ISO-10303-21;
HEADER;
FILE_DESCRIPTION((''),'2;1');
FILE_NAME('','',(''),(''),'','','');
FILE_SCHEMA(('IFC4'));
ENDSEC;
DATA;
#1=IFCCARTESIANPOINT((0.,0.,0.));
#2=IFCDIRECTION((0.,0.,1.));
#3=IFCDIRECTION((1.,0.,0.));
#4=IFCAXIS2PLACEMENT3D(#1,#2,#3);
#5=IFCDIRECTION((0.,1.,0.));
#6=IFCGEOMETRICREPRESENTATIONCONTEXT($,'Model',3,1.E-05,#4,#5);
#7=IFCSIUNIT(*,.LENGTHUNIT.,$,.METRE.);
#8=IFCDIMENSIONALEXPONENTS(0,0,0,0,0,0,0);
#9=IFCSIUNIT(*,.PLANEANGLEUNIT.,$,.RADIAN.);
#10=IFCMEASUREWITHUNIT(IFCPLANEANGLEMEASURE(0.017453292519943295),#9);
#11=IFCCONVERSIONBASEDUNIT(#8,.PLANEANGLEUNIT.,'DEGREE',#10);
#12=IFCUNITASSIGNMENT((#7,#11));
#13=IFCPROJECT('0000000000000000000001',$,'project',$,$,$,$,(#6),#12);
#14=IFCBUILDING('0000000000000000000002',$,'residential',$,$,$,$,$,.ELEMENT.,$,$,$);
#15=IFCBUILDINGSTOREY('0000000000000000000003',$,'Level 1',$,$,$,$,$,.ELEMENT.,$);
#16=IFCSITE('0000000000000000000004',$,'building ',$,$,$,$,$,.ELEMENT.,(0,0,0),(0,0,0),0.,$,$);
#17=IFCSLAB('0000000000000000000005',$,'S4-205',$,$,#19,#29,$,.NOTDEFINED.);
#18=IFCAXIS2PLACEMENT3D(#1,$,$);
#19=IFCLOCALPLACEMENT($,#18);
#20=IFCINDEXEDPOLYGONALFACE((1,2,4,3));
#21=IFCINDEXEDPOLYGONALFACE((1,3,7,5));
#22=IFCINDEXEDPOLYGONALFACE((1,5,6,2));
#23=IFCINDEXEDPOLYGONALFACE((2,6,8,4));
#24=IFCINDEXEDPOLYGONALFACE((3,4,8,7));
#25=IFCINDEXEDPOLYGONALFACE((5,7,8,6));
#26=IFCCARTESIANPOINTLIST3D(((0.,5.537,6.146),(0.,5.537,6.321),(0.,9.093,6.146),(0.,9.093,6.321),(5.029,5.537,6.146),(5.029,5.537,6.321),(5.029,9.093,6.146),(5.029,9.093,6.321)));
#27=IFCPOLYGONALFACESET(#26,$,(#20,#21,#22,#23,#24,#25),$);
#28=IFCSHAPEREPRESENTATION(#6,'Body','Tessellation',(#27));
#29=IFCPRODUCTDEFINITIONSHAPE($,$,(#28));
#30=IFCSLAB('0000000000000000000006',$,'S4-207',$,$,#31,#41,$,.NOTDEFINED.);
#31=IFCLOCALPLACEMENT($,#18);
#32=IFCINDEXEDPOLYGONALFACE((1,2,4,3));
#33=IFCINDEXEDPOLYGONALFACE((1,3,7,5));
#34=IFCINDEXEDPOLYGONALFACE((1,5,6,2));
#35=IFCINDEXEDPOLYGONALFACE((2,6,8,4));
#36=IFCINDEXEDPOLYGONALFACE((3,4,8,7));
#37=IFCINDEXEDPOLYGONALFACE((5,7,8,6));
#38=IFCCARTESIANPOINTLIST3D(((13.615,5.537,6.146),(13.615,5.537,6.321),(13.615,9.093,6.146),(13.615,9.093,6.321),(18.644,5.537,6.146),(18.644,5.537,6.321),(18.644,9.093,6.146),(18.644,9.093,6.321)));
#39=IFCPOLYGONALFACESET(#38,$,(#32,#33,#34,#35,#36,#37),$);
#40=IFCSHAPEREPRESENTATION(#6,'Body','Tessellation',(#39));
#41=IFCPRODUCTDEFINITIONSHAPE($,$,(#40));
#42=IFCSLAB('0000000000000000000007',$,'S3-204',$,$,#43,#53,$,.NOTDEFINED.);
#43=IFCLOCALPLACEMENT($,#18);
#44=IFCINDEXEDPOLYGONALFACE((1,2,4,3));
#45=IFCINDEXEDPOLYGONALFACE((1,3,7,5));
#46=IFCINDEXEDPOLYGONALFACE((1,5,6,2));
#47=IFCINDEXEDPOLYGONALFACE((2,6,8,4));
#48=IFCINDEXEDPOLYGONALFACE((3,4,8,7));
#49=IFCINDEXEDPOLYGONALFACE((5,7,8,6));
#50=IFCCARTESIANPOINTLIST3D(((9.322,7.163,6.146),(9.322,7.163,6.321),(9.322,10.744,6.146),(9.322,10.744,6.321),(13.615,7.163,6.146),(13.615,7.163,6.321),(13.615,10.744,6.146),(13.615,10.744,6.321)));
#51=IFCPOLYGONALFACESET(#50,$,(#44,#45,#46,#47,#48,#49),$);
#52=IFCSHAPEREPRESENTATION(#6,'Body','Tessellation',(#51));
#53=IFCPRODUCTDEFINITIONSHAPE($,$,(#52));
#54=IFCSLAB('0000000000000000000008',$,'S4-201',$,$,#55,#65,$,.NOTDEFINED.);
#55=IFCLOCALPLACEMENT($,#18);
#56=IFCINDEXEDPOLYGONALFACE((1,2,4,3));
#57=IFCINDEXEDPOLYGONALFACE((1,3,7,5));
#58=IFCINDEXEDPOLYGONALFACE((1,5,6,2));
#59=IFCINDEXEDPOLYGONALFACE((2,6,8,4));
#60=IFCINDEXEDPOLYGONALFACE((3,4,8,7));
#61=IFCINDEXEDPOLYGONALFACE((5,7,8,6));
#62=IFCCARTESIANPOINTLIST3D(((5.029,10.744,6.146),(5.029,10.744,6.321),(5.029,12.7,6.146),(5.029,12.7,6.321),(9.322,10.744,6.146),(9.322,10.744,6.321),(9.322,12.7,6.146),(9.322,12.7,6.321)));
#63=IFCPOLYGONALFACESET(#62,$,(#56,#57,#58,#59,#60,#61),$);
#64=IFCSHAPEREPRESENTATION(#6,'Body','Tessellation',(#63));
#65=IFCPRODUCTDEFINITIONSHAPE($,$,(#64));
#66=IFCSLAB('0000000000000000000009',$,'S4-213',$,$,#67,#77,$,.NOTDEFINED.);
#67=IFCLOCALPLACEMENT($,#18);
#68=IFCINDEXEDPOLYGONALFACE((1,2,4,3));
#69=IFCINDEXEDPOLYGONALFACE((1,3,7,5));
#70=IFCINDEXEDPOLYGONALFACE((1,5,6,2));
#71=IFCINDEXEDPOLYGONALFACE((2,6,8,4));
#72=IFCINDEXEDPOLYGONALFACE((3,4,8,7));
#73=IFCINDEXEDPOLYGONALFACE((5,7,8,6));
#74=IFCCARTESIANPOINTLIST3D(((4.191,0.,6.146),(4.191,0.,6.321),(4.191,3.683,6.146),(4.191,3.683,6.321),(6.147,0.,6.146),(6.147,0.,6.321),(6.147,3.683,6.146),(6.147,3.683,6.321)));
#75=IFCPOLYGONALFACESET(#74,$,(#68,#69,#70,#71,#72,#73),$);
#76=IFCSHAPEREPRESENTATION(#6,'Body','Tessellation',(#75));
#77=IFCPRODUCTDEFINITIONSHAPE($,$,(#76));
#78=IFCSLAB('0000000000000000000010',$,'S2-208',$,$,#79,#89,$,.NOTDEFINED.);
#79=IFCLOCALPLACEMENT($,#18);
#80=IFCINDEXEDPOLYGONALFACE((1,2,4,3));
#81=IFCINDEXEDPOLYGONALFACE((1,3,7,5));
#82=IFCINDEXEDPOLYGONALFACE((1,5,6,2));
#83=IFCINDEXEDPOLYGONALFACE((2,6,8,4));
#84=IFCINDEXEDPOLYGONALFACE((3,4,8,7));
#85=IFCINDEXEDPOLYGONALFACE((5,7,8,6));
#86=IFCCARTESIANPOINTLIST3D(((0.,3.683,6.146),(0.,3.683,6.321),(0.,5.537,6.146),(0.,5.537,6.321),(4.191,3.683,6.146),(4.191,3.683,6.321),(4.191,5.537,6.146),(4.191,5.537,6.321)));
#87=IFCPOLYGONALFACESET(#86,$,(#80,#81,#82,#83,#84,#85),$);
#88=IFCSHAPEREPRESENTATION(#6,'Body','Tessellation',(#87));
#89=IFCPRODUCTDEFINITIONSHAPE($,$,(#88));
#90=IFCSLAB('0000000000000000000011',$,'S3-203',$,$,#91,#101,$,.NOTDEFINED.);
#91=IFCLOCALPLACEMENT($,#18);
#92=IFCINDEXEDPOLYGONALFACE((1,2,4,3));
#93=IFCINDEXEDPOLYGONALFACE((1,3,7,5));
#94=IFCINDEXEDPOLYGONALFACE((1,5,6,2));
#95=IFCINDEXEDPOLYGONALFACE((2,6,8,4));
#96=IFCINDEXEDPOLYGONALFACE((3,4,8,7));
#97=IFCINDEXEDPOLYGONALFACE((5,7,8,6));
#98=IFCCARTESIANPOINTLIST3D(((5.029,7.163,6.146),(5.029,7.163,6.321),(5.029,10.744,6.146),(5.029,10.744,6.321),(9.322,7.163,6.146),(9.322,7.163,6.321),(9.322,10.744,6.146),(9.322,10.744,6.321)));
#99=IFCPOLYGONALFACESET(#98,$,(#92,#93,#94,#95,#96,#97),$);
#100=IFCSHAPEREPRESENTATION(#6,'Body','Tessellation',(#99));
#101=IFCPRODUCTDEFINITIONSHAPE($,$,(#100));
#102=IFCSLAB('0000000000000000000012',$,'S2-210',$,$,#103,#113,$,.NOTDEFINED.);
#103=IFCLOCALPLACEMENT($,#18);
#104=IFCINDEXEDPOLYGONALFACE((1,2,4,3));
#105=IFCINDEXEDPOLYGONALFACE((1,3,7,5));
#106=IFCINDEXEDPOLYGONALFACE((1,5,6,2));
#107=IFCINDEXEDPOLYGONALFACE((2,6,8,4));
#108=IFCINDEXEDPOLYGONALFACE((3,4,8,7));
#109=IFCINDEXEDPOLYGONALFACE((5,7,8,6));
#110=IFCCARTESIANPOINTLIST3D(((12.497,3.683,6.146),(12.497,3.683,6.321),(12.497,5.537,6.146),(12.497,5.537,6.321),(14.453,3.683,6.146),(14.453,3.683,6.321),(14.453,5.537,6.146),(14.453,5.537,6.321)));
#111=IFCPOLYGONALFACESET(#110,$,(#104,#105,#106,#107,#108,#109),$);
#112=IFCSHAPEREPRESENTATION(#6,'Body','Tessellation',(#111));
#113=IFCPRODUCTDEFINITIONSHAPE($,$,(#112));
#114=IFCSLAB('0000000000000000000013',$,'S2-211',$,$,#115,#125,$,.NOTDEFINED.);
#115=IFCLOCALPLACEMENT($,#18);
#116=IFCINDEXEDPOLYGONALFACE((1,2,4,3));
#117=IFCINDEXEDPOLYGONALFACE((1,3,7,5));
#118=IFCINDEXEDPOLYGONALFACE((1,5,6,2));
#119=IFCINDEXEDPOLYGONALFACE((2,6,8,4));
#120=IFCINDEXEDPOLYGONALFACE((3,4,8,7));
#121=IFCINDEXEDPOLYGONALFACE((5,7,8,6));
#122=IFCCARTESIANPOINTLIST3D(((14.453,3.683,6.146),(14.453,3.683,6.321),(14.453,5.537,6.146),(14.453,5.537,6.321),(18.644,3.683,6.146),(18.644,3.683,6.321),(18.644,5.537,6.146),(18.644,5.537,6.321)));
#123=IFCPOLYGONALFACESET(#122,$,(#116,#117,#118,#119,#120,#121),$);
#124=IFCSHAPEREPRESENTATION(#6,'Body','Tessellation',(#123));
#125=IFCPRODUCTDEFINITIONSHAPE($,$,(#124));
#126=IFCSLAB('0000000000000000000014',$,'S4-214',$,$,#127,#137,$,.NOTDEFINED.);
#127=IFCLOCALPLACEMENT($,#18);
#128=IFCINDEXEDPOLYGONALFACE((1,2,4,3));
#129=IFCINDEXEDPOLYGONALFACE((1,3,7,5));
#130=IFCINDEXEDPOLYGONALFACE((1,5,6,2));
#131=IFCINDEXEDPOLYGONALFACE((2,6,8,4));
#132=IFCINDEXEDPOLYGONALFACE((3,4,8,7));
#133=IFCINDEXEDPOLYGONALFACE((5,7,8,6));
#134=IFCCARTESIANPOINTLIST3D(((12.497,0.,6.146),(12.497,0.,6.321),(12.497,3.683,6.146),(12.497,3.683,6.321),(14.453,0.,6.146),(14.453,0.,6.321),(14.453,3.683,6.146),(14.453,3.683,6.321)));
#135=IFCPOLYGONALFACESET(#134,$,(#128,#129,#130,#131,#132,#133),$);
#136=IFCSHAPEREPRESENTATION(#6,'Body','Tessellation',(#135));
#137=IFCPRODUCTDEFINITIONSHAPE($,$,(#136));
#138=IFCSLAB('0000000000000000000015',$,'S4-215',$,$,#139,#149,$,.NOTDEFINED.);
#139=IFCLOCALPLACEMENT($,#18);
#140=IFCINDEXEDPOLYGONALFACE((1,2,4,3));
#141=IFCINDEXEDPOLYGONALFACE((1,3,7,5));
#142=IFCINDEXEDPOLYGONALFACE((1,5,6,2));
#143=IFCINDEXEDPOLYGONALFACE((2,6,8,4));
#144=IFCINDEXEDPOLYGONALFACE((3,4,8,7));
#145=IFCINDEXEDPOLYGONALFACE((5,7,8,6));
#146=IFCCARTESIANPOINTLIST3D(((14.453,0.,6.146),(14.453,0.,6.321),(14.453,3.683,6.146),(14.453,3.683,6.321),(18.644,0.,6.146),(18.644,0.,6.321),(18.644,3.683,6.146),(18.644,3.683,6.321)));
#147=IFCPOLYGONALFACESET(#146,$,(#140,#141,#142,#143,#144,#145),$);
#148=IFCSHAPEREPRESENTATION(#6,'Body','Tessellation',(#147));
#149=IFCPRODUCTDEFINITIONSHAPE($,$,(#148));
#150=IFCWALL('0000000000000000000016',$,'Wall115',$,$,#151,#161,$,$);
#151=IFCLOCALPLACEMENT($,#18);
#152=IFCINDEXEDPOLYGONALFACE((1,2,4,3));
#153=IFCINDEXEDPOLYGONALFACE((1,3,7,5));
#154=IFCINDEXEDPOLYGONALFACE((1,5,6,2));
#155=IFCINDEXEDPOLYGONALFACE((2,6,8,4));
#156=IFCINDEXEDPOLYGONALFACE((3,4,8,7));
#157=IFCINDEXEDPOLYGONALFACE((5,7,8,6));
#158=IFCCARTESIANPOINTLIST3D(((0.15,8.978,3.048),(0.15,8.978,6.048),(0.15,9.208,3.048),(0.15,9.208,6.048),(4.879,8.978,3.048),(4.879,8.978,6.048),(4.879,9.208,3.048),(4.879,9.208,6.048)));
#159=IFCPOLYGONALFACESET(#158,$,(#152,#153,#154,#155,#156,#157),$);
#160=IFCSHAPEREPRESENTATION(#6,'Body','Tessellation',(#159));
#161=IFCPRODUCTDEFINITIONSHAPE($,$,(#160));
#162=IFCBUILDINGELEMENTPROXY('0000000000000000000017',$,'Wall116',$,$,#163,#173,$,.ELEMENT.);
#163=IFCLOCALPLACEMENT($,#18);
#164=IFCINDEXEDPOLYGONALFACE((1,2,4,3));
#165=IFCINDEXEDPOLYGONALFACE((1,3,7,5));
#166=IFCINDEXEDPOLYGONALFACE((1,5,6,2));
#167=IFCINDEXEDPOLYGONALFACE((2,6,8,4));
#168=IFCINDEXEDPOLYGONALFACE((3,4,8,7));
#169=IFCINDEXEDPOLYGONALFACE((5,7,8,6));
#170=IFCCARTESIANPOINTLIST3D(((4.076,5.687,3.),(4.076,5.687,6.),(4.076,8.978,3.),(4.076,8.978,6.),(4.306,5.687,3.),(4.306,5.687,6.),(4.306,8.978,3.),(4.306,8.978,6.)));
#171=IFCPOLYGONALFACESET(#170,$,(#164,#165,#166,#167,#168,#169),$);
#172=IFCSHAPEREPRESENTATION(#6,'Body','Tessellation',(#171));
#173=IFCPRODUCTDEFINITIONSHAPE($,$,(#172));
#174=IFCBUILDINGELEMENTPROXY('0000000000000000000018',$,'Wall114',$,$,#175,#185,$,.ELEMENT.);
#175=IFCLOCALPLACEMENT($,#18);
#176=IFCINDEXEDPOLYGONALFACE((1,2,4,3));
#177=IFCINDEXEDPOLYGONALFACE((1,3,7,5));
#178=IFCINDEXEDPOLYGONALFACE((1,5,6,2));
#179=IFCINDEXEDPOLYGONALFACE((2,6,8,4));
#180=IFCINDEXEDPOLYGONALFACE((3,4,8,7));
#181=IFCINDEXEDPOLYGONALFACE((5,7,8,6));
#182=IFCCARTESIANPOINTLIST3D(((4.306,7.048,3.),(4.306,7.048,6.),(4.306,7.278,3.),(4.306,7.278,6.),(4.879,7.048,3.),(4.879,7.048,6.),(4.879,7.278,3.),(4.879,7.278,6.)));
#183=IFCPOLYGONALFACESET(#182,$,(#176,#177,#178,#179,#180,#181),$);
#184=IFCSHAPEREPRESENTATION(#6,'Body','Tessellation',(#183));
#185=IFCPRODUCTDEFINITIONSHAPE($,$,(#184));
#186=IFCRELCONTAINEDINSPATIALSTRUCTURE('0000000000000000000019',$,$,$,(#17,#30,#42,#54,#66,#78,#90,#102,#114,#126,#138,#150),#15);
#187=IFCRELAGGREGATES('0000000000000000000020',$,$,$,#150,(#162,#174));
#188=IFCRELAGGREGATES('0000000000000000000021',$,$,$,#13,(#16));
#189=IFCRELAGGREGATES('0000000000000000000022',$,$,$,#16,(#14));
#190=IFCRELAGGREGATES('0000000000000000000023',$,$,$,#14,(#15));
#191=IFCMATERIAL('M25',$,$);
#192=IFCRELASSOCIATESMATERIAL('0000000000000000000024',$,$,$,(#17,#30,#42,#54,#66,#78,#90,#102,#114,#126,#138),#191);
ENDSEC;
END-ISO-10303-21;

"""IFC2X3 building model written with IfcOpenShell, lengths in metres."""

from ifc_helpers import new_model, entity, si_unit, converted_unit, direction, frame, frame_2d, origin_with_axes, place, context, project, spatial, rectangle, extrude, material, element, aggregate, save


model = new_model("IFC2X3")

# Units and contexts
model_context = context("Model", 3, precision=1e-05, world=origin_with_axes(), true_north=direction((0.0, 1.0, 0.0)))
ifc_project = project(units=[si_unit("LENGTHUNIT", "METRE"), converted_unit("PLANEANGLEUNIT", "DEGREE", entity("IfcPlaneAngleMeasure", 0.017453292519943295), si_unit("PLANEANGLEUNIT", "RADIAN"), dimensions=[0, 0, 0, 0, 0, 0, 0])], contexts=[model_context])

# Site, building, storey
site = spatial("IfcSite", under=ifc_project, Name="building ", CompositionType="ELEMENT", RefLatitude=(0, 0, 0), RefLongitude=(0, 0, 0), RefElevation=0.0)
building = spatial("IfcBuilding", under=site, Name="residential", CompositionType="ELEMENT")
storey = spatial("IfcBuildingStorey", under=building, Name="Level 1", CompositionType="ELEMENT")

# Slabs
ifc_material = material(Name="M25")
placement = place(None, origin_with_axes())
element("IfcSlab", 1, at=placement, inside=storey, material=ifc_material, Name="S4-205", PredefinedType="NOTDEFINED", context=model_context, shape_type="SweptSolid", body=[
    extrude(rectangle(XDim=5.029, YDim=3.556, at=frame_2d((0.0, 0.0), x_axis=(1.0, 0.0, 0.0))), frame((2.5145, 7.315, 6.146), z_axis=(0.0, 0.0, 1.0), x_axis=(1.0, 0.0, 0.0)), (0.0, 0.0, 1.0), 0.175),
])
element("IfcSlab", 2, at=placement, inside=storey, material=ifc_material, Name="S4-207", PredefinedType="NOTDEFINED", context=model_context, shape_type="SweptSolid", body=[
    extrude(rectangle(XDim=5.029, YDim=3.556, at=frame_2d((0.0, 0.0), x_axis=(1.0, 0.0, 0.0))), frame((16.1295, 7.315, 6.146), z_axis=(0.0, 0.0, 1.0), x_axis=(1.0, 0.0, 0.0)), (0.0, 0.0, 1.0), 0.175),
])
element("IfcSlab", 3, at=placement, inside=storey, material=ifc_material, Name="S3-204", PredefinedType="NOTDEFINED", context=model_context, shape_type="SweptSolid", body=[
    extrude(rectangle(XDim=4.293, YDim=3.581, at=frame_2d((0.0, 0.0), x_axis=(1.0, 0.0, 0.0))), frame((11.4685, 8.9535, 6.146), z_axis=(0.0, 0.0, 1.0), x_axis=(1.0, 0.0, 0.0)), (0.0, 0.0, 1.0), 0.175),
])
element("IfcSlab", 4, at=placement, inside=storey, material=ifc_material, Name="S4-201", PredefinedType="NOTDEFINED", context=model_context, shape_type="SweptSolid", body=[
    extrude(rectangle(XDim=4.293, YDim=1.956, at=frame_2d((0.0, 0.0), x_axis=(1.0, 0.0, 0.0))), frame((7.1755, 11.722, 6.146), z_axis=(0.0, 0.0, 1.0), x_axis=(1.0, 0.0, 0.0)), (0.0, 0.0, 1.0), 0.175),
])
element("IfcSlab", 5, at=placement, inside=storey, material=ifc_material, Name="S4-213", PredefinedType="NOTDEFINED", context=model_context, shape_type="SweptSolid", body=[
    extrude(rectangle(XDim=1.956, YDim=3.683, at=frame_2d((0.0, 0.0), x_axis=(1.0, 0.0, 0.0))), frame((5.169, 1.8415, 6.146), z_axis=(0.0, 0.0, 1.0), x_axis=(1.0, 0.0, 0.0)), (0.0, 0.0, 1.0), 0.175),
])
element("IfcSlab", 6, at=placement, inside=storey, material=ifc_material, Name="S2-208", PredefinedType="NOTDEFINED", context=model_context, shape_type="SweptSolid", body=[
    extrude(rectangle(XDim=4.191, YDim=1.854, at=frame_2d((0.0, 0.0), x_axis=(1.0, 0.0, 0.0))), frame((2.0955, 4.61, 6.146), z_axis=(0.0, 0.0, 1.0), x_axis=(1.0, 0.0, 0.0)), (0.0, 0.0, 1.0), 0.175),
])
element("IfcSlab", 7, at=placement, inside=storey, material=ifc_material, Name="S3-203", PredefinedType="NOTDEFINED", context=model_context, shape_type="SweptSolid", body=[
    extrude(rectangle(XDim=4.293, YDim=3.581, at=frame_2d((0.0, 0.0), x_axis=(1.0, 0.0, 0.0))), frame((7.1755, 8.9535, 6.146), z_axis=(0.0, 0.0, 1.0), x_axis=(1.0, 0.0, 0.0)), (0.0, 0.0, 1.0), 0.175),
])
element("IfcSlab", 8, at=placement, inside=storey, material=ifc_material, Name="S2-210", PredefinedType="NOTDEFINED", context=model_context, shape_type="SweptSolid", body=[
    extrude(rectangle(XDim=1.956, YDim=1.854, at=frame_2d((0.0, 0.0), x_axis=(1.0, 0.0, 0.0))), frame((13.475, 4.61, 6.146), z_axis=(0.0, 0.0, 1.0), x_axis=(1.0, 0.0, 0.0)), (0.0, 0.0, 1.0), 0.175),
])
element("IfcSlab", 9, at=placement, inside=storey, material=ifc_material, Name="S2-211", PredefinedType="NOTDEFINED", context=model_context, shape_type="SweptSolid", body=[
    extrude(rectangle(XDim=4.191, YDim=1.854, at=frame_2d((0.0, 0.0), x_axis=(1.0, 0.0, 0.0))), frame((16.5485, 4.61, 6.146), z_axis=(0.0, 0.0, 1.0), x_axis=(1.0, 0.0, 0.0)), (0.0, 0.0, 1.0), 0.175),
])
element("IfcSlab", 10, at=placement, inside=storey, material=ifc_material, Name="S4-214", PredefinedType="NOTDEFINED", context=model_context, shape_type="SweptSolid", body=[
    extrude(rectangle(XDim=1.956, YDim=3.683, at=frame_2d((0.0, 0.0), x_axis=(1.0, 0.0, 0.0))), frame((13.475, 1.8415, 6.146), z_axis=(0.0, 0.0, 1.0), x_axis=(1.0, 0.0, 0.0)), (0.0, 0.0, 1.0), 0.175),
])
element("IfcSlab", 11, at=placement, inside=storey, material=ifc_material, Name="S4-215", PredefinedType="NOTDEFINED", context=model_context, shape_type="SweptSolid", body=[
    extrude(rectangle(XDim=4.191, YDim=3.683, at=frame_2d((0.0, 0.0), x_axis=(1.0, 0.0, 0.0))), frame((16.5485, 1.8415, 6.146), z_axis=(0.0, 0.0, 1.0), x_axis=(1.0, 0.0, 0.0)), (0.0, 0.0, 1.0), 0.175),
])

# Wall
wall_1 = element("IfcWall", 12, at=placement, inside=storey, Name="Wall115", context=model_context, shape_type="SweptSolid", body=[
    extrude(rectangle(XDim=4.729, YDim=0.23, at=frame_2d((0.0, 0.0), x_axis=(1.0, 0.0, 0.0))), frame((2.5145, 9.093, 3.048), z_axis=(0.0, 0.0, 1.0), x_axis=(1.0, 0.0, 0.0)), (0.0, 0.0, 1.0), 3.0),
])

# Building element proxies
proxy_1 = element("IfcBuildingElementProxy", 13, at=placement, Name="Wall116", CompositionType="ELEMENT", context=model_context, shape_type="SweptSolid", body=[
    extrude(rectangle(XDim=3.291, YDim=0.23, at=frame_2d((0.0, 0.0), x_axis=(0.0, 1.0, 0.0))), frame((4.191, 7.3325, 3.0), z_axis=(0.0, 0.0, 1.0), x_axis=(1.0, 0.0, 0.0)), (0.0, 0.0, 1.0), 3.0),
])
proxy_2 = element("IfcBuildingElementProxy", 14, at=placement, Name="Wall114", CompositionType="ELEMENT", context=model_context, shape_type="SweptSolid", body=[
    extrude(rectangle(XDim=0.573, YDim=0.23, at=frame_2d((0.0, 0.0), x_axis=(-1.0, 0.0, 0.0))), frame((4.5925, 7.163, 3.0), z_axis=(0.0, 0.0, 1.0), x_axis=(1.0, 0.0, 0.0)), (0.0, 0.0, 1.0), 3.0),
])
aggregate(wall_1, [proxy_1, proxy_2])

save(model, "model.ifc")
